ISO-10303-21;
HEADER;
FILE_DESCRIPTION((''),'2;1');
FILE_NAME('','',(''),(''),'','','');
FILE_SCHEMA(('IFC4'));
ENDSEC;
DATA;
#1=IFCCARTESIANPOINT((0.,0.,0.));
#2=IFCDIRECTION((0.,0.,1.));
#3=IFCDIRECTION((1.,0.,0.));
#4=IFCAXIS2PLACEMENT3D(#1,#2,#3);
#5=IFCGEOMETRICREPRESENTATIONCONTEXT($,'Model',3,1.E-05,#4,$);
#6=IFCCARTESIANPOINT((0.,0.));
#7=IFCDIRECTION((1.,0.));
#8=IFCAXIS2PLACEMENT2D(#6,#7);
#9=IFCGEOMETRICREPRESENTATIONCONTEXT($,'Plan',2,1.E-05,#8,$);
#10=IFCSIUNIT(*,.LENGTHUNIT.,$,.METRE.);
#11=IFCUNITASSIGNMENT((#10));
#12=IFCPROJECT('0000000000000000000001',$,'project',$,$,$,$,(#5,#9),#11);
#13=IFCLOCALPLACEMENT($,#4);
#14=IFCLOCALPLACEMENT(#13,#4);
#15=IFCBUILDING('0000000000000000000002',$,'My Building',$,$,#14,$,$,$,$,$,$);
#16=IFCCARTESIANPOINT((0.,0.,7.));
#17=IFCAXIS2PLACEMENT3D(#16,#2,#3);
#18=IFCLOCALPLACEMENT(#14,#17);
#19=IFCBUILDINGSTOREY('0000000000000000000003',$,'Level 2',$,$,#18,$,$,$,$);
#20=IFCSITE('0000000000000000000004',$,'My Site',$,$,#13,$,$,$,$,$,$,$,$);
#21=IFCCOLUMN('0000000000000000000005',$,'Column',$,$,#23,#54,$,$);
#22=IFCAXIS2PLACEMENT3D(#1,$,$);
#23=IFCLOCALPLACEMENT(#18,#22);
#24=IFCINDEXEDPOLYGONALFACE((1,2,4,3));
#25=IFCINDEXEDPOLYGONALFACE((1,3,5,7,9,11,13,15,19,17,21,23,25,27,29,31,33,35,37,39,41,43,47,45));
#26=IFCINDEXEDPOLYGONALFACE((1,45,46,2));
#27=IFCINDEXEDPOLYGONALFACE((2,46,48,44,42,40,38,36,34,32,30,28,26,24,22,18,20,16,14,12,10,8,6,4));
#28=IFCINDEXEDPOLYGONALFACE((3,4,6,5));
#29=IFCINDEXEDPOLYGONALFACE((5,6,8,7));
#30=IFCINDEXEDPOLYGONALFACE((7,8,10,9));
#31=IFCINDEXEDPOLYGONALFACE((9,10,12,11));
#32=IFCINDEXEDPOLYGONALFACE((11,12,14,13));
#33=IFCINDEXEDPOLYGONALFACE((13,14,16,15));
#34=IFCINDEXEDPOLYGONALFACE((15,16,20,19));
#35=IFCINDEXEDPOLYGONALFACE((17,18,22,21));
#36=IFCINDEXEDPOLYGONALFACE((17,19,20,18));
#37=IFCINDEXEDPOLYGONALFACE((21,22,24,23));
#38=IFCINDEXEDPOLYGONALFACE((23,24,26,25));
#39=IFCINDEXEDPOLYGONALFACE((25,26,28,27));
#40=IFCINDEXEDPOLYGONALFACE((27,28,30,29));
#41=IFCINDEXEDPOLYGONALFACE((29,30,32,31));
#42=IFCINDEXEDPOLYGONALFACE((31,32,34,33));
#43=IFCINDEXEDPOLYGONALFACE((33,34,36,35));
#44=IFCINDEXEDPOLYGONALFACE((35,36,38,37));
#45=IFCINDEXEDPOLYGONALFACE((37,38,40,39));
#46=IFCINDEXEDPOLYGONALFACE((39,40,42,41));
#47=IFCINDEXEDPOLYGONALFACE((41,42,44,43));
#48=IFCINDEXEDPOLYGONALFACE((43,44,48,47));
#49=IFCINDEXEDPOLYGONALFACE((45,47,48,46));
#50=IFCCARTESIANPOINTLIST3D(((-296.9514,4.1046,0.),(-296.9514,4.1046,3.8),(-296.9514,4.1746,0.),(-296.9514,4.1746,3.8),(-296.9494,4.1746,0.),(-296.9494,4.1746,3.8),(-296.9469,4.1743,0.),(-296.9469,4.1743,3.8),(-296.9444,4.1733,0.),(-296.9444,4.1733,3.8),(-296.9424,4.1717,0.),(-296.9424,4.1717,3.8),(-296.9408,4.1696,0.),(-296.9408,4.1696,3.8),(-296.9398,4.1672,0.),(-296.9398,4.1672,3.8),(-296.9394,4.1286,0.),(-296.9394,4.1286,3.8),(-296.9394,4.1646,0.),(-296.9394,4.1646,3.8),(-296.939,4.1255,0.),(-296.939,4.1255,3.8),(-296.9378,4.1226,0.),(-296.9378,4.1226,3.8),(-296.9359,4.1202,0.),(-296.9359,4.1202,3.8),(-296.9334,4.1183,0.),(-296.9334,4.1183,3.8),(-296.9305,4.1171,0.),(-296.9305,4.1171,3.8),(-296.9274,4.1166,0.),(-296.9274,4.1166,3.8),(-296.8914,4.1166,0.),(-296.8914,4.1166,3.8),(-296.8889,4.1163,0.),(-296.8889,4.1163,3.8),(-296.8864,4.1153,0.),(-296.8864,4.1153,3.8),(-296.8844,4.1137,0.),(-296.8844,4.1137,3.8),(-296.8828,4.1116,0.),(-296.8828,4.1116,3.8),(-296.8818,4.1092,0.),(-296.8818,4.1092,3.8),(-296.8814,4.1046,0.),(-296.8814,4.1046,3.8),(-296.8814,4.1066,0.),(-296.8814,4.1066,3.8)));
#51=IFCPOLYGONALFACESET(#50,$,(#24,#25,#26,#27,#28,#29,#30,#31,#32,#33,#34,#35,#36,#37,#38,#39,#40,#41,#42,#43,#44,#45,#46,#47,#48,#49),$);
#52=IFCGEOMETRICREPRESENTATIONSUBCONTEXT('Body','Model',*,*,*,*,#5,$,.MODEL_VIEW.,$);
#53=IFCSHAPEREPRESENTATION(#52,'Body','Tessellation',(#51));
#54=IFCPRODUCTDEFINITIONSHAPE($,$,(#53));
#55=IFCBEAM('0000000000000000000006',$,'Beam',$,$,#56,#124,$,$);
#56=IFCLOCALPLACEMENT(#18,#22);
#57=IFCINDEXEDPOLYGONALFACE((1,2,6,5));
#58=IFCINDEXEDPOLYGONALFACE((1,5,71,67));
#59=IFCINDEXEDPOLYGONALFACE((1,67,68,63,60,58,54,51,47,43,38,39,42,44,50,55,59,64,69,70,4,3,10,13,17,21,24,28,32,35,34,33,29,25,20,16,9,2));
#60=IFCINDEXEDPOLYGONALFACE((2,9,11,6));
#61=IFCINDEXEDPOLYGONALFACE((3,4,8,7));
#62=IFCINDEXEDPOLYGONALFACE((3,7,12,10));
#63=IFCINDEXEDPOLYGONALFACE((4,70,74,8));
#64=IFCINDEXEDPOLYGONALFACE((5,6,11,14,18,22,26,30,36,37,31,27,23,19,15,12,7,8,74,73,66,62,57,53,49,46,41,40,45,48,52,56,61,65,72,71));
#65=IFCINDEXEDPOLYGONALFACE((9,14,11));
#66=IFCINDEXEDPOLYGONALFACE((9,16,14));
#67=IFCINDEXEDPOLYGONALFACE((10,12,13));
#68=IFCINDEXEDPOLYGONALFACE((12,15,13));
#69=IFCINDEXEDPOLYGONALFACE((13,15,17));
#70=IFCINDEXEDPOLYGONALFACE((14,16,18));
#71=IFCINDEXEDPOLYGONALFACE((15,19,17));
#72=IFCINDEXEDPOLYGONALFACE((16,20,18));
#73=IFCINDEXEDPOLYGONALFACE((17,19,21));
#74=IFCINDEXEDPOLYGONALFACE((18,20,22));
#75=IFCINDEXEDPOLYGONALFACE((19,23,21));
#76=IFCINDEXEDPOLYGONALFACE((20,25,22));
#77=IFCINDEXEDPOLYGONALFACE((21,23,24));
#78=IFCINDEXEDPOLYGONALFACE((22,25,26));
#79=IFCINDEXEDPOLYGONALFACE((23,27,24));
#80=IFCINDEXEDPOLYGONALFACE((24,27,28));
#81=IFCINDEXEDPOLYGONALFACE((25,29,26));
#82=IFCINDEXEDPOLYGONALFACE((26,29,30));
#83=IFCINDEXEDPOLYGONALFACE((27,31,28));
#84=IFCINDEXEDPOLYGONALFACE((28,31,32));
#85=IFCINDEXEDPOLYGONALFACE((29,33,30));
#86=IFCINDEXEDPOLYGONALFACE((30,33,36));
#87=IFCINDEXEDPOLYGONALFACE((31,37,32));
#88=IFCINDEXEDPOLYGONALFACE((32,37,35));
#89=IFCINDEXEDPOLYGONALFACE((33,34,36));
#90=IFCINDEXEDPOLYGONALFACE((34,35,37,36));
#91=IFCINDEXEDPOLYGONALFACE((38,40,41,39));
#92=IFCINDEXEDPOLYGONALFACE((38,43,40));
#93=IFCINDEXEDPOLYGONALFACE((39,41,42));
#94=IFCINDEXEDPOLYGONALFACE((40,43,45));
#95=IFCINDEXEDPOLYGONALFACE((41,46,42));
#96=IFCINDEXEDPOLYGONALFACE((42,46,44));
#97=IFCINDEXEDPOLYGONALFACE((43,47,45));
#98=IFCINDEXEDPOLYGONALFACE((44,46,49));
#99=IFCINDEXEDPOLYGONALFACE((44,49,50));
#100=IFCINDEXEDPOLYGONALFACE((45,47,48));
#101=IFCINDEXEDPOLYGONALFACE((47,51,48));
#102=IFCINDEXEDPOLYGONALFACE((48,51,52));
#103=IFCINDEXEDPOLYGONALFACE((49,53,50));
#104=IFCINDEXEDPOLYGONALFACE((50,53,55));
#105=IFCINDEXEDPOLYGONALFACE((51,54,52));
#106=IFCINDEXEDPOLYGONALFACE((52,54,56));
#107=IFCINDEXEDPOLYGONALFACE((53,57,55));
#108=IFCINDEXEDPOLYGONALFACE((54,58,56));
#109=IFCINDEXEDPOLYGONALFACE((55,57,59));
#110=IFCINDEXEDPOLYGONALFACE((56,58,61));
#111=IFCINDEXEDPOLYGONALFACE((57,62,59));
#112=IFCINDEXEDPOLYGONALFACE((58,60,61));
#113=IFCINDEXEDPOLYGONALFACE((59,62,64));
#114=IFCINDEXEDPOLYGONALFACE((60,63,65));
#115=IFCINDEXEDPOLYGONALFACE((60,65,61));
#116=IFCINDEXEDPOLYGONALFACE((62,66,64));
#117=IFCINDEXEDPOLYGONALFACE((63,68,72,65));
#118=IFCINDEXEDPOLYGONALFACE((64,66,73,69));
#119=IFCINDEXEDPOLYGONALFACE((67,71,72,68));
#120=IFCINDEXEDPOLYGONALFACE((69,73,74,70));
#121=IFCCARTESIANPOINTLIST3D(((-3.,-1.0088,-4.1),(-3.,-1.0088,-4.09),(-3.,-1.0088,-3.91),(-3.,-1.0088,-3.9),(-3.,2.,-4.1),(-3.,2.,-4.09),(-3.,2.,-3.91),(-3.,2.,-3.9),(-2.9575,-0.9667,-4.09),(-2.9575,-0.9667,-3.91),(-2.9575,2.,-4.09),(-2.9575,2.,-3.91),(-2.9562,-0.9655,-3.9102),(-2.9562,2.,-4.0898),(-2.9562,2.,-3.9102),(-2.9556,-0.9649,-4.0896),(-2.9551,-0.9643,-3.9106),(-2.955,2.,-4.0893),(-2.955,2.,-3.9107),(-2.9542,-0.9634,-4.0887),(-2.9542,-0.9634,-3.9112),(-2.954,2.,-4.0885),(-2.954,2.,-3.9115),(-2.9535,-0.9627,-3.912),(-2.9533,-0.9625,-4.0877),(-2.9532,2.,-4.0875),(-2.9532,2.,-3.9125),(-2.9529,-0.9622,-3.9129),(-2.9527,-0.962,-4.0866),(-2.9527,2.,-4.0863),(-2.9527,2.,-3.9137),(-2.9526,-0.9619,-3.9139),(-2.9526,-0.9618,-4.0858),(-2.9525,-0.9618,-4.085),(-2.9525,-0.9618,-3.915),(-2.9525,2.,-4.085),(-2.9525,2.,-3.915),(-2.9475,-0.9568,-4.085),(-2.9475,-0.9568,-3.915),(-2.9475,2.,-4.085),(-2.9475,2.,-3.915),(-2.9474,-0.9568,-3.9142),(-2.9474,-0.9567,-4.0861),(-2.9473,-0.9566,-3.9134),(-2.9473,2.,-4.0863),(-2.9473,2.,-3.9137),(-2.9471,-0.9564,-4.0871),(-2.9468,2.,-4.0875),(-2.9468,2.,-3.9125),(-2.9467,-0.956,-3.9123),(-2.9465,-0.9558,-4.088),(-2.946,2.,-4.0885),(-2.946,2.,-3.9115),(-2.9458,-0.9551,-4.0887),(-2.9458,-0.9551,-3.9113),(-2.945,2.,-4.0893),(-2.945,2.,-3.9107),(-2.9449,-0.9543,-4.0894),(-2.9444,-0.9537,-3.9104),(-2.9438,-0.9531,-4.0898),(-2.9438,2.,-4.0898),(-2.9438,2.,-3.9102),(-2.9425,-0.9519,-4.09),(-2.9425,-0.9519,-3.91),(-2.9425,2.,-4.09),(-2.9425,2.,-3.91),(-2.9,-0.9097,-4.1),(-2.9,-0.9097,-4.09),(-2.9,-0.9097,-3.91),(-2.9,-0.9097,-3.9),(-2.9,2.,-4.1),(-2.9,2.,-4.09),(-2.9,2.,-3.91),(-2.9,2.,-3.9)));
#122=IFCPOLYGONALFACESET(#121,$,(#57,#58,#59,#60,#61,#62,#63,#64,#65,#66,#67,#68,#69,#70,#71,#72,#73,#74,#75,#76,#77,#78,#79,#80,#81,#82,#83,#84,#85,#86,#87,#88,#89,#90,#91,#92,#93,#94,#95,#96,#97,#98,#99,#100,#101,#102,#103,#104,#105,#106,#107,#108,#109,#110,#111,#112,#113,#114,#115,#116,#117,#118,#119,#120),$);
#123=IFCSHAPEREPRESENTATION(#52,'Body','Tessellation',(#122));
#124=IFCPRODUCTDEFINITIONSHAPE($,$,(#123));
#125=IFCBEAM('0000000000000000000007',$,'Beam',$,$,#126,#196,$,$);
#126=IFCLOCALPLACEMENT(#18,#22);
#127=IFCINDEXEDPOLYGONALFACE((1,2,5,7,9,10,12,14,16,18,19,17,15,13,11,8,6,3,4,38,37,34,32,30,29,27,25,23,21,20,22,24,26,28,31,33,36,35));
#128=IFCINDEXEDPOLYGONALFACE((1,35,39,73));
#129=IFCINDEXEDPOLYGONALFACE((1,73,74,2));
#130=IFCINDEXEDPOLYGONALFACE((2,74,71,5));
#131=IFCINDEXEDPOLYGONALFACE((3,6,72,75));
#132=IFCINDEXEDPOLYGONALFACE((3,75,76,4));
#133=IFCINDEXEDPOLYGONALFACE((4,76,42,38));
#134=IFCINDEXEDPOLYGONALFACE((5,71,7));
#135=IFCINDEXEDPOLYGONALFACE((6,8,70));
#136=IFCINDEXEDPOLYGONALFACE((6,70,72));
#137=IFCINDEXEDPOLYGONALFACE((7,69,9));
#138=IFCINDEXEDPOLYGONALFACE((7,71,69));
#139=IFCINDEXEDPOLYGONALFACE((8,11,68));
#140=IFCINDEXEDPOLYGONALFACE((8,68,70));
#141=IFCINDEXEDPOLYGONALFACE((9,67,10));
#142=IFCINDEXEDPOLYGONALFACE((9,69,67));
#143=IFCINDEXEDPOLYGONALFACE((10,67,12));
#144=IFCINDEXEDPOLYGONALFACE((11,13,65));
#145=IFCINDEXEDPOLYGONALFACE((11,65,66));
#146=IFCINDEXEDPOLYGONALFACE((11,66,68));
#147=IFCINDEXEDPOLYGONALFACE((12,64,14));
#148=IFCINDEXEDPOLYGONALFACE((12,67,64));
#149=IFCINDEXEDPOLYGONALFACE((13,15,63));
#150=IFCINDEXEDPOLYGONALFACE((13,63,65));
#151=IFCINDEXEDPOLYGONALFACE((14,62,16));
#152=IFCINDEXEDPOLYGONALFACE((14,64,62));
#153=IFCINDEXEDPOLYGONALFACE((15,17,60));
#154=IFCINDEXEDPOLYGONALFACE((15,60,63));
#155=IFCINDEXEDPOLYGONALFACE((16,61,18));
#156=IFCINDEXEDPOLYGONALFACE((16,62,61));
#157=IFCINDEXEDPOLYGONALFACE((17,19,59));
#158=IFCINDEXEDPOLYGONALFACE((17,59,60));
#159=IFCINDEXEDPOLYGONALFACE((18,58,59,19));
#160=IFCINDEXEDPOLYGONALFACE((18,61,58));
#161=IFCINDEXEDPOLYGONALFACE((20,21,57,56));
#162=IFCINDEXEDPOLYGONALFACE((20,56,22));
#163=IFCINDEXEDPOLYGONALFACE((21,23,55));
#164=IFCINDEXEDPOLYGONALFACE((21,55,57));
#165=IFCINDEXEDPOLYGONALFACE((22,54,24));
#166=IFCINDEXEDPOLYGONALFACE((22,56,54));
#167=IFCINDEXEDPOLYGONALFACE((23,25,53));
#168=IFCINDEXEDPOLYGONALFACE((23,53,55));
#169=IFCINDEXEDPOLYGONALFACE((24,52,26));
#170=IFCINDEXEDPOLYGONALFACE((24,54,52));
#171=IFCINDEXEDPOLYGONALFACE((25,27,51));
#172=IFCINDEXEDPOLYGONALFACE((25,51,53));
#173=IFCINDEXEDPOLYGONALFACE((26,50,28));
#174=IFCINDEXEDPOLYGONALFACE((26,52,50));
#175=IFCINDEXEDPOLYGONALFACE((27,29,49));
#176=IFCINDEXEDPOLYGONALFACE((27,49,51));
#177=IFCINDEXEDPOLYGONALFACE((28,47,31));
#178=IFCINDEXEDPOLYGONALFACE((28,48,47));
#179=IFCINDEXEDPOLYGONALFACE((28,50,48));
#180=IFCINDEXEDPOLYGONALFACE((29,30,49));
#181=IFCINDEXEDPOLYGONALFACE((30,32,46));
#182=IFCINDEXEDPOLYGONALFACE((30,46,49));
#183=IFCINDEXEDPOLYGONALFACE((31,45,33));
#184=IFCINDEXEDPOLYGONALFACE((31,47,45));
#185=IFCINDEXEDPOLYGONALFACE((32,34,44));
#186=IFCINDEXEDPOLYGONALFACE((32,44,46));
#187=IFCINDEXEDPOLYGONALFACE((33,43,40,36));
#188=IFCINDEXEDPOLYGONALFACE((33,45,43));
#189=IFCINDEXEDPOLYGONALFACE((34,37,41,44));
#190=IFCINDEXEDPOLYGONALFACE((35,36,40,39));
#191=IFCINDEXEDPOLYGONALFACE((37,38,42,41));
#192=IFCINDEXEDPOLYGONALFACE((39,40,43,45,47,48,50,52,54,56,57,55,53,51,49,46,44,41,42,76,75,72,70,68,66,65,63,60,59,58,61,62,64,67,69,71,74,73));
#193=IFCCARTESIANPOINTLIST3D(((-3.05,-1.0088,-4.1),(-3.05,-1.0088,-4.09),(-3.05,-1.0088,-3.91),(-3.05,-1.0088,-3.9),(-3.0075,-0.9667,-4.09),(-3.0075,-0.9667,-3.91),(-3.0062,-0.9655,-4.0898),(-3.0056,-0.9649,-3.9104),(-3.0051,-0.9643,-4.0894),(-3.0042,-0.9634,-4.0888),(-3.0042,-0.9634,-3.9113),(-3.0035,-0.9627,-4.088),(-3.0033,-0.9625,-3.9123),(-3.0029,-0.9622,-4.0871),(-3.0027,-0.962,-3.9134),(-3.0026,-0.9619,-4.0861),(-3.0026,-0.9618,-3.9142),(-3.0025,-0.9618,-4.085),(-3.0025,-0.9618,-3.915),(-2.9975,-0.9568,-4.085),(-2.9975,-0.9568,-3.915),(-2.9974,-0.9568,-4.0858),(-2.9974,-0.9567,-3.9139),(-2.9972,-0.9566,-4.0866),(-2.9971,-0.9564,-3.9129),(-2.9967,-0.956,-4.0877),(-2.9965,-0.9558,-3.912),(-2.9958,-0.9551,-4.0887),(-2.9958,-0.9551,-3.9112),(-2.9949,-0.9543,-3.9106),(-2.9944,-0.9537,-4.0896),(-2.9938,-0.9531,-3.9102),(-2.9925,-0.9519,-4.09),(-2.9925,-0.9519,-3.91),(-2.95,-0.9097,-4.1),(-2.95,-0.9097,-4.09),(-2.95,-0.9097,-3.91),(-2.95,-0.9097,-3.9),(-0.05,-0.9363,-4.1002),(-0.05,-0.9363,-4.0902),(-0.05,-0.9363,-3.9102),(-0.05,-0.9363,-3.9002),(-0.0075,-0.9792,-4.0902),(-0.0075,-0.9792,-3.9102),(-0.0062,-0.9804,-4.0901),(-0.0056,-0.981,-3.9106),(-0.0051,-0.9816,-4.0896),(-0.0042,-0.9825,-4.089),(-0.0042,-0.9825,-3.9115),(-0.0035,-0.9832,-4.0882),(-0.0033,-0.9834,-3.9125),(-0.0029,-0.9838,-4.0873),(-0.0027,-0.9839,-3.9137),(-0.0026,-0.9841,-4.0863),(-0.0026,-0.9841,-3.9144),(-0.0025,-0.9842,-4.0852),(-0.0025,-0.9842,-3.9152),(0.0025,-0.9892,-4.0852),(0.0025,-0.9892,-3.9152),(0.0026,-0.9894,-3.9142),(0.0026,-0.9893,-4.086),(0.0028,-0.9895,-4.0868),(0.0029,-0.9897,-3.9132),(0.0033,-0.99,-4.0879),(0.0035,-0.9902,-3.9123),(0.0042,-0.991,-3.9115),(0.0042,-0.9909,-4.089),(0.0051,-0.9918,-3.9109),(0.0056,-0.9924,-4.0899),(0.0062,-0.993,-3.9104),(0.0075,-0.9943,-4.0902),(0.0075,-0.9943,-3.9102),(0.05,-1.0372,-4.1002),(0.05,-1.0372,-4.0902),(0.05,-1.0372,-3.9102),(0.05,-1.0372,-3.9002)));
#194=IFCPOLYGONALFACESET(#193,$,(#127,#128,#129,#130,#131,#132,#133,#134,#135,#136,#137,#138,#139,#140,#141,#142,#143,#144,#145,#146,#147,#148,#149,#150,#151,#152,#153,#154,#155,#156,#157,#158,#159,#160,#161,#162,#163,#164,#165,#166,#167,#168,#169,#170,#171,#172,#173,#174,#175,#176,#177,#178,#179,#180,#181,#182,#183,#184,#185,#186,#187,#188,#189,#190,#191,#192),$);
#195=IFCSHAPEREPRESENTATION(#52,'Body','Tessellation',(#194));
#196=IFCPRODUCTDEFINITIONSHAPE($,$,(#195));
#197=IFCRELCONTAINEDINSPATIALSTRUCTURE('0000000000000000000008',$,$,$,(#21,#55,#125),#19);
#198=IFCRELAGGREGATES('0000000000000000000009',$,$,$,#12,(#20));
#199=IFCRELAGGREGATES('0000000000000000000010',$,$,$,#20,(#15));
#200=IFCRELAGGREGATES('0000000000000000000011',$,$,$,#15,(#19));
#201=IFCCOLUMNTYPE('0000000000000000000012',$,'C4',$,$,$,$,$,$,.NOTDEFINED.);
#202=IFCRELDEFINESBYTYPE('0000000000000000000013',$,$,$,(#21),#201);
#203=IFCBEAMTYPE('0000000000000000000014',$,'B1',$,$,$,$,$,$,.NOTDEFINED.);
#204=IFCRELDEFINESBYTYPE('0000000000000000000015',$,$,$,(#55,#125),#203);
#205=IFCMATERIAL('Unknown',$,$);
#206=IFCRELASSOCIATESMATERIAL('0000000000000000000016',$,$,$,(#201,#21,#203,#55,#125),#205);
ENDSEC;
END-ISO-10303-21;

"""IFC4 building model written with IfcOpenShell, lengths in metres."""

from ifc_helpers import new_model, si_unit, frame, origin_with_axes, origin_2d_with_axis, place, context, subcontext, project, spatial, i_section, l_section, extrude, clip, halfspace, material, material_profile, profile_set, profile_usage, type_object, element, save


model = new_model("IFC4")

# Units and contexts
model_context = context("Model", 3, precision=1e-05, world=origin_with_axes())
plan_context = context("Plan", 2, precision=1e-05, world=origin_2d_with_axis())
body_context = subcontext(model_context, "Body", "Model", "MODEL_VIEW")
ifc_project = project(units=[si_unit("LENGTHUNIT", "METRE")], contexts=[model_context, plan_context])

# Site, building, storey
site_placement = place(None, origin_with_axes())
site = spatial("IfcSite", under=ifc_project, at=site_placement, Name="My Site")
building_placement = place(site_placement, origin_with_axes())
building = spatial("IfcBuilding", under=site, at=building_placement, Name="My Building")
storey_placement = place(building_placement, frame((0.0, 0.0, 7.0), z_axis=(0.0, 0.0, 1.0), x_axis=(1.0, 0.0, 0.0)))
storey = spatial("IfcBuildingStorey", under=building, at=storey_placement, Name="Level 2")

# Column
ifc_material = material(Name="Unknown")
ifc_material_profile_1 = material_profile(ifc_material, l_section(Depth=0.07, Width=0.07, Thickness=0.012, FilletRadius=0.012, EdgeRadius=0.01))
ifc_profile_set_1 = profile_set([ifc_material_profile_1], Name="C4")
column_type_1 = type_object("IfcColumnType", Name="C4", PredefinedType="NOTDEFINED", material=ifc_profile_set_1)
ifc_profile_usage_1 = profile_usage(ifc_profile_set_1, cardinal=5)
column_1_placement = place(storey_placement, frame((-296.9164, 4.1396, 0.0), z_axis=(0.0, 0.0, 1.0), x_axis=(1.0, 0.0, 0.0)))
element("IfcColumn", 1, at=column_1_placement, inside=storey, type_object=column_type_1, material=ifc_profile_usage_1, Name="Column", context=body_context, shape_type="SweptSolid", body=[
    extrude(l_section(Depth=0.07, Width=0.07, Thickness=0.012, FilletRadius=0.012, EdgeRadius=0.01), origin_with_axes(), (0.0, 0.0, 1.0), 3.8),
])

# Beams
ifc_material_profile_2 = material_profile(ifc_material, i_section(OverallWidth=0.1, OverallDepth=0.2, WebThickness=0.005, FlangeThickness=0.01, FilletRadius=0.005))
ifc_profile_set_2 = profile_set([ifc_material_profile_2])
ifc_profile_usage_2 = profile_usage(ifc_profile_set_2, cardinal=5)
beam_type_1 = type_object("IfcBeamType", Name="B1", PredefinedType="NOTDEFINED", material=ifc_profile_set_2)
beam_1_placement = place(storey_placement, frame((-2.95, 2.0, -4.0), z_axis=(0.0, -1.0, 0.0), x_axis=(1.0, 0.0, 0.0)))
element("IfcBeam", 2, at=beam_1_placement, inside=storey, type_object=beam_type_1, material=ifc_profile_usage_2, Name="Beam", context=body_context, shape_type="Clipping", body=[
    clip(extrude(i_section(OverallWidth=0.1, OverallDepth=0.2, WebThickness=0.005, FlangeThickness=0.01, FilletRadius=0.005), origin_with_axes(), (0.0, 0.0, 1.0), 3.2093), halfspace(frame((-0.05, -3.0, 3.0088), z_axis=(0.703867, 0.0, 0.710332), x_axis=(0.0, -1.0, 0.0)), False)),
])
ifc_profile_usage_3 = profile_usage(ifc_profile_set_2, cardinal=5)
beam_2_placement = place(storey_placement, frame((-3.25, -0.957, -4.0), z_axis=(0.999958, -0.009144, -0.000074), x_axis=(0.009144, 0.999958, 0.0)))
element("IfcBeam", 3, at=beam_2_placement, inside=storey, type_object=beam_type_1, material=ifc_profile_usage_3, Name="Beam", context=body_context, shape_type="Clipping", body=[
    clip(clip(extrude(i_section(OverallWidth=0.1, OverallDepth=0.2, WebThickness=0.005, FlangeThickness=0.01, FilletRadius=0.005), origin_with_axes(), (0.0, 0.0, 1.0), 3.5001), halfspace(frame((-0.05, -2.9998, 3.3008), z_axis=(0.710332, 0.000052, 0.703867), x_axis=(0.000073, -1.0, 0.0)), False)), halfspace(frame((-0.05, -3.0, 0.2007), z_axis=(0.703866, -0.000052, -0.710333), x_axis=(-0.000074, -1.0, 0.0)), False)),
])

save(model, "model.ifc")
